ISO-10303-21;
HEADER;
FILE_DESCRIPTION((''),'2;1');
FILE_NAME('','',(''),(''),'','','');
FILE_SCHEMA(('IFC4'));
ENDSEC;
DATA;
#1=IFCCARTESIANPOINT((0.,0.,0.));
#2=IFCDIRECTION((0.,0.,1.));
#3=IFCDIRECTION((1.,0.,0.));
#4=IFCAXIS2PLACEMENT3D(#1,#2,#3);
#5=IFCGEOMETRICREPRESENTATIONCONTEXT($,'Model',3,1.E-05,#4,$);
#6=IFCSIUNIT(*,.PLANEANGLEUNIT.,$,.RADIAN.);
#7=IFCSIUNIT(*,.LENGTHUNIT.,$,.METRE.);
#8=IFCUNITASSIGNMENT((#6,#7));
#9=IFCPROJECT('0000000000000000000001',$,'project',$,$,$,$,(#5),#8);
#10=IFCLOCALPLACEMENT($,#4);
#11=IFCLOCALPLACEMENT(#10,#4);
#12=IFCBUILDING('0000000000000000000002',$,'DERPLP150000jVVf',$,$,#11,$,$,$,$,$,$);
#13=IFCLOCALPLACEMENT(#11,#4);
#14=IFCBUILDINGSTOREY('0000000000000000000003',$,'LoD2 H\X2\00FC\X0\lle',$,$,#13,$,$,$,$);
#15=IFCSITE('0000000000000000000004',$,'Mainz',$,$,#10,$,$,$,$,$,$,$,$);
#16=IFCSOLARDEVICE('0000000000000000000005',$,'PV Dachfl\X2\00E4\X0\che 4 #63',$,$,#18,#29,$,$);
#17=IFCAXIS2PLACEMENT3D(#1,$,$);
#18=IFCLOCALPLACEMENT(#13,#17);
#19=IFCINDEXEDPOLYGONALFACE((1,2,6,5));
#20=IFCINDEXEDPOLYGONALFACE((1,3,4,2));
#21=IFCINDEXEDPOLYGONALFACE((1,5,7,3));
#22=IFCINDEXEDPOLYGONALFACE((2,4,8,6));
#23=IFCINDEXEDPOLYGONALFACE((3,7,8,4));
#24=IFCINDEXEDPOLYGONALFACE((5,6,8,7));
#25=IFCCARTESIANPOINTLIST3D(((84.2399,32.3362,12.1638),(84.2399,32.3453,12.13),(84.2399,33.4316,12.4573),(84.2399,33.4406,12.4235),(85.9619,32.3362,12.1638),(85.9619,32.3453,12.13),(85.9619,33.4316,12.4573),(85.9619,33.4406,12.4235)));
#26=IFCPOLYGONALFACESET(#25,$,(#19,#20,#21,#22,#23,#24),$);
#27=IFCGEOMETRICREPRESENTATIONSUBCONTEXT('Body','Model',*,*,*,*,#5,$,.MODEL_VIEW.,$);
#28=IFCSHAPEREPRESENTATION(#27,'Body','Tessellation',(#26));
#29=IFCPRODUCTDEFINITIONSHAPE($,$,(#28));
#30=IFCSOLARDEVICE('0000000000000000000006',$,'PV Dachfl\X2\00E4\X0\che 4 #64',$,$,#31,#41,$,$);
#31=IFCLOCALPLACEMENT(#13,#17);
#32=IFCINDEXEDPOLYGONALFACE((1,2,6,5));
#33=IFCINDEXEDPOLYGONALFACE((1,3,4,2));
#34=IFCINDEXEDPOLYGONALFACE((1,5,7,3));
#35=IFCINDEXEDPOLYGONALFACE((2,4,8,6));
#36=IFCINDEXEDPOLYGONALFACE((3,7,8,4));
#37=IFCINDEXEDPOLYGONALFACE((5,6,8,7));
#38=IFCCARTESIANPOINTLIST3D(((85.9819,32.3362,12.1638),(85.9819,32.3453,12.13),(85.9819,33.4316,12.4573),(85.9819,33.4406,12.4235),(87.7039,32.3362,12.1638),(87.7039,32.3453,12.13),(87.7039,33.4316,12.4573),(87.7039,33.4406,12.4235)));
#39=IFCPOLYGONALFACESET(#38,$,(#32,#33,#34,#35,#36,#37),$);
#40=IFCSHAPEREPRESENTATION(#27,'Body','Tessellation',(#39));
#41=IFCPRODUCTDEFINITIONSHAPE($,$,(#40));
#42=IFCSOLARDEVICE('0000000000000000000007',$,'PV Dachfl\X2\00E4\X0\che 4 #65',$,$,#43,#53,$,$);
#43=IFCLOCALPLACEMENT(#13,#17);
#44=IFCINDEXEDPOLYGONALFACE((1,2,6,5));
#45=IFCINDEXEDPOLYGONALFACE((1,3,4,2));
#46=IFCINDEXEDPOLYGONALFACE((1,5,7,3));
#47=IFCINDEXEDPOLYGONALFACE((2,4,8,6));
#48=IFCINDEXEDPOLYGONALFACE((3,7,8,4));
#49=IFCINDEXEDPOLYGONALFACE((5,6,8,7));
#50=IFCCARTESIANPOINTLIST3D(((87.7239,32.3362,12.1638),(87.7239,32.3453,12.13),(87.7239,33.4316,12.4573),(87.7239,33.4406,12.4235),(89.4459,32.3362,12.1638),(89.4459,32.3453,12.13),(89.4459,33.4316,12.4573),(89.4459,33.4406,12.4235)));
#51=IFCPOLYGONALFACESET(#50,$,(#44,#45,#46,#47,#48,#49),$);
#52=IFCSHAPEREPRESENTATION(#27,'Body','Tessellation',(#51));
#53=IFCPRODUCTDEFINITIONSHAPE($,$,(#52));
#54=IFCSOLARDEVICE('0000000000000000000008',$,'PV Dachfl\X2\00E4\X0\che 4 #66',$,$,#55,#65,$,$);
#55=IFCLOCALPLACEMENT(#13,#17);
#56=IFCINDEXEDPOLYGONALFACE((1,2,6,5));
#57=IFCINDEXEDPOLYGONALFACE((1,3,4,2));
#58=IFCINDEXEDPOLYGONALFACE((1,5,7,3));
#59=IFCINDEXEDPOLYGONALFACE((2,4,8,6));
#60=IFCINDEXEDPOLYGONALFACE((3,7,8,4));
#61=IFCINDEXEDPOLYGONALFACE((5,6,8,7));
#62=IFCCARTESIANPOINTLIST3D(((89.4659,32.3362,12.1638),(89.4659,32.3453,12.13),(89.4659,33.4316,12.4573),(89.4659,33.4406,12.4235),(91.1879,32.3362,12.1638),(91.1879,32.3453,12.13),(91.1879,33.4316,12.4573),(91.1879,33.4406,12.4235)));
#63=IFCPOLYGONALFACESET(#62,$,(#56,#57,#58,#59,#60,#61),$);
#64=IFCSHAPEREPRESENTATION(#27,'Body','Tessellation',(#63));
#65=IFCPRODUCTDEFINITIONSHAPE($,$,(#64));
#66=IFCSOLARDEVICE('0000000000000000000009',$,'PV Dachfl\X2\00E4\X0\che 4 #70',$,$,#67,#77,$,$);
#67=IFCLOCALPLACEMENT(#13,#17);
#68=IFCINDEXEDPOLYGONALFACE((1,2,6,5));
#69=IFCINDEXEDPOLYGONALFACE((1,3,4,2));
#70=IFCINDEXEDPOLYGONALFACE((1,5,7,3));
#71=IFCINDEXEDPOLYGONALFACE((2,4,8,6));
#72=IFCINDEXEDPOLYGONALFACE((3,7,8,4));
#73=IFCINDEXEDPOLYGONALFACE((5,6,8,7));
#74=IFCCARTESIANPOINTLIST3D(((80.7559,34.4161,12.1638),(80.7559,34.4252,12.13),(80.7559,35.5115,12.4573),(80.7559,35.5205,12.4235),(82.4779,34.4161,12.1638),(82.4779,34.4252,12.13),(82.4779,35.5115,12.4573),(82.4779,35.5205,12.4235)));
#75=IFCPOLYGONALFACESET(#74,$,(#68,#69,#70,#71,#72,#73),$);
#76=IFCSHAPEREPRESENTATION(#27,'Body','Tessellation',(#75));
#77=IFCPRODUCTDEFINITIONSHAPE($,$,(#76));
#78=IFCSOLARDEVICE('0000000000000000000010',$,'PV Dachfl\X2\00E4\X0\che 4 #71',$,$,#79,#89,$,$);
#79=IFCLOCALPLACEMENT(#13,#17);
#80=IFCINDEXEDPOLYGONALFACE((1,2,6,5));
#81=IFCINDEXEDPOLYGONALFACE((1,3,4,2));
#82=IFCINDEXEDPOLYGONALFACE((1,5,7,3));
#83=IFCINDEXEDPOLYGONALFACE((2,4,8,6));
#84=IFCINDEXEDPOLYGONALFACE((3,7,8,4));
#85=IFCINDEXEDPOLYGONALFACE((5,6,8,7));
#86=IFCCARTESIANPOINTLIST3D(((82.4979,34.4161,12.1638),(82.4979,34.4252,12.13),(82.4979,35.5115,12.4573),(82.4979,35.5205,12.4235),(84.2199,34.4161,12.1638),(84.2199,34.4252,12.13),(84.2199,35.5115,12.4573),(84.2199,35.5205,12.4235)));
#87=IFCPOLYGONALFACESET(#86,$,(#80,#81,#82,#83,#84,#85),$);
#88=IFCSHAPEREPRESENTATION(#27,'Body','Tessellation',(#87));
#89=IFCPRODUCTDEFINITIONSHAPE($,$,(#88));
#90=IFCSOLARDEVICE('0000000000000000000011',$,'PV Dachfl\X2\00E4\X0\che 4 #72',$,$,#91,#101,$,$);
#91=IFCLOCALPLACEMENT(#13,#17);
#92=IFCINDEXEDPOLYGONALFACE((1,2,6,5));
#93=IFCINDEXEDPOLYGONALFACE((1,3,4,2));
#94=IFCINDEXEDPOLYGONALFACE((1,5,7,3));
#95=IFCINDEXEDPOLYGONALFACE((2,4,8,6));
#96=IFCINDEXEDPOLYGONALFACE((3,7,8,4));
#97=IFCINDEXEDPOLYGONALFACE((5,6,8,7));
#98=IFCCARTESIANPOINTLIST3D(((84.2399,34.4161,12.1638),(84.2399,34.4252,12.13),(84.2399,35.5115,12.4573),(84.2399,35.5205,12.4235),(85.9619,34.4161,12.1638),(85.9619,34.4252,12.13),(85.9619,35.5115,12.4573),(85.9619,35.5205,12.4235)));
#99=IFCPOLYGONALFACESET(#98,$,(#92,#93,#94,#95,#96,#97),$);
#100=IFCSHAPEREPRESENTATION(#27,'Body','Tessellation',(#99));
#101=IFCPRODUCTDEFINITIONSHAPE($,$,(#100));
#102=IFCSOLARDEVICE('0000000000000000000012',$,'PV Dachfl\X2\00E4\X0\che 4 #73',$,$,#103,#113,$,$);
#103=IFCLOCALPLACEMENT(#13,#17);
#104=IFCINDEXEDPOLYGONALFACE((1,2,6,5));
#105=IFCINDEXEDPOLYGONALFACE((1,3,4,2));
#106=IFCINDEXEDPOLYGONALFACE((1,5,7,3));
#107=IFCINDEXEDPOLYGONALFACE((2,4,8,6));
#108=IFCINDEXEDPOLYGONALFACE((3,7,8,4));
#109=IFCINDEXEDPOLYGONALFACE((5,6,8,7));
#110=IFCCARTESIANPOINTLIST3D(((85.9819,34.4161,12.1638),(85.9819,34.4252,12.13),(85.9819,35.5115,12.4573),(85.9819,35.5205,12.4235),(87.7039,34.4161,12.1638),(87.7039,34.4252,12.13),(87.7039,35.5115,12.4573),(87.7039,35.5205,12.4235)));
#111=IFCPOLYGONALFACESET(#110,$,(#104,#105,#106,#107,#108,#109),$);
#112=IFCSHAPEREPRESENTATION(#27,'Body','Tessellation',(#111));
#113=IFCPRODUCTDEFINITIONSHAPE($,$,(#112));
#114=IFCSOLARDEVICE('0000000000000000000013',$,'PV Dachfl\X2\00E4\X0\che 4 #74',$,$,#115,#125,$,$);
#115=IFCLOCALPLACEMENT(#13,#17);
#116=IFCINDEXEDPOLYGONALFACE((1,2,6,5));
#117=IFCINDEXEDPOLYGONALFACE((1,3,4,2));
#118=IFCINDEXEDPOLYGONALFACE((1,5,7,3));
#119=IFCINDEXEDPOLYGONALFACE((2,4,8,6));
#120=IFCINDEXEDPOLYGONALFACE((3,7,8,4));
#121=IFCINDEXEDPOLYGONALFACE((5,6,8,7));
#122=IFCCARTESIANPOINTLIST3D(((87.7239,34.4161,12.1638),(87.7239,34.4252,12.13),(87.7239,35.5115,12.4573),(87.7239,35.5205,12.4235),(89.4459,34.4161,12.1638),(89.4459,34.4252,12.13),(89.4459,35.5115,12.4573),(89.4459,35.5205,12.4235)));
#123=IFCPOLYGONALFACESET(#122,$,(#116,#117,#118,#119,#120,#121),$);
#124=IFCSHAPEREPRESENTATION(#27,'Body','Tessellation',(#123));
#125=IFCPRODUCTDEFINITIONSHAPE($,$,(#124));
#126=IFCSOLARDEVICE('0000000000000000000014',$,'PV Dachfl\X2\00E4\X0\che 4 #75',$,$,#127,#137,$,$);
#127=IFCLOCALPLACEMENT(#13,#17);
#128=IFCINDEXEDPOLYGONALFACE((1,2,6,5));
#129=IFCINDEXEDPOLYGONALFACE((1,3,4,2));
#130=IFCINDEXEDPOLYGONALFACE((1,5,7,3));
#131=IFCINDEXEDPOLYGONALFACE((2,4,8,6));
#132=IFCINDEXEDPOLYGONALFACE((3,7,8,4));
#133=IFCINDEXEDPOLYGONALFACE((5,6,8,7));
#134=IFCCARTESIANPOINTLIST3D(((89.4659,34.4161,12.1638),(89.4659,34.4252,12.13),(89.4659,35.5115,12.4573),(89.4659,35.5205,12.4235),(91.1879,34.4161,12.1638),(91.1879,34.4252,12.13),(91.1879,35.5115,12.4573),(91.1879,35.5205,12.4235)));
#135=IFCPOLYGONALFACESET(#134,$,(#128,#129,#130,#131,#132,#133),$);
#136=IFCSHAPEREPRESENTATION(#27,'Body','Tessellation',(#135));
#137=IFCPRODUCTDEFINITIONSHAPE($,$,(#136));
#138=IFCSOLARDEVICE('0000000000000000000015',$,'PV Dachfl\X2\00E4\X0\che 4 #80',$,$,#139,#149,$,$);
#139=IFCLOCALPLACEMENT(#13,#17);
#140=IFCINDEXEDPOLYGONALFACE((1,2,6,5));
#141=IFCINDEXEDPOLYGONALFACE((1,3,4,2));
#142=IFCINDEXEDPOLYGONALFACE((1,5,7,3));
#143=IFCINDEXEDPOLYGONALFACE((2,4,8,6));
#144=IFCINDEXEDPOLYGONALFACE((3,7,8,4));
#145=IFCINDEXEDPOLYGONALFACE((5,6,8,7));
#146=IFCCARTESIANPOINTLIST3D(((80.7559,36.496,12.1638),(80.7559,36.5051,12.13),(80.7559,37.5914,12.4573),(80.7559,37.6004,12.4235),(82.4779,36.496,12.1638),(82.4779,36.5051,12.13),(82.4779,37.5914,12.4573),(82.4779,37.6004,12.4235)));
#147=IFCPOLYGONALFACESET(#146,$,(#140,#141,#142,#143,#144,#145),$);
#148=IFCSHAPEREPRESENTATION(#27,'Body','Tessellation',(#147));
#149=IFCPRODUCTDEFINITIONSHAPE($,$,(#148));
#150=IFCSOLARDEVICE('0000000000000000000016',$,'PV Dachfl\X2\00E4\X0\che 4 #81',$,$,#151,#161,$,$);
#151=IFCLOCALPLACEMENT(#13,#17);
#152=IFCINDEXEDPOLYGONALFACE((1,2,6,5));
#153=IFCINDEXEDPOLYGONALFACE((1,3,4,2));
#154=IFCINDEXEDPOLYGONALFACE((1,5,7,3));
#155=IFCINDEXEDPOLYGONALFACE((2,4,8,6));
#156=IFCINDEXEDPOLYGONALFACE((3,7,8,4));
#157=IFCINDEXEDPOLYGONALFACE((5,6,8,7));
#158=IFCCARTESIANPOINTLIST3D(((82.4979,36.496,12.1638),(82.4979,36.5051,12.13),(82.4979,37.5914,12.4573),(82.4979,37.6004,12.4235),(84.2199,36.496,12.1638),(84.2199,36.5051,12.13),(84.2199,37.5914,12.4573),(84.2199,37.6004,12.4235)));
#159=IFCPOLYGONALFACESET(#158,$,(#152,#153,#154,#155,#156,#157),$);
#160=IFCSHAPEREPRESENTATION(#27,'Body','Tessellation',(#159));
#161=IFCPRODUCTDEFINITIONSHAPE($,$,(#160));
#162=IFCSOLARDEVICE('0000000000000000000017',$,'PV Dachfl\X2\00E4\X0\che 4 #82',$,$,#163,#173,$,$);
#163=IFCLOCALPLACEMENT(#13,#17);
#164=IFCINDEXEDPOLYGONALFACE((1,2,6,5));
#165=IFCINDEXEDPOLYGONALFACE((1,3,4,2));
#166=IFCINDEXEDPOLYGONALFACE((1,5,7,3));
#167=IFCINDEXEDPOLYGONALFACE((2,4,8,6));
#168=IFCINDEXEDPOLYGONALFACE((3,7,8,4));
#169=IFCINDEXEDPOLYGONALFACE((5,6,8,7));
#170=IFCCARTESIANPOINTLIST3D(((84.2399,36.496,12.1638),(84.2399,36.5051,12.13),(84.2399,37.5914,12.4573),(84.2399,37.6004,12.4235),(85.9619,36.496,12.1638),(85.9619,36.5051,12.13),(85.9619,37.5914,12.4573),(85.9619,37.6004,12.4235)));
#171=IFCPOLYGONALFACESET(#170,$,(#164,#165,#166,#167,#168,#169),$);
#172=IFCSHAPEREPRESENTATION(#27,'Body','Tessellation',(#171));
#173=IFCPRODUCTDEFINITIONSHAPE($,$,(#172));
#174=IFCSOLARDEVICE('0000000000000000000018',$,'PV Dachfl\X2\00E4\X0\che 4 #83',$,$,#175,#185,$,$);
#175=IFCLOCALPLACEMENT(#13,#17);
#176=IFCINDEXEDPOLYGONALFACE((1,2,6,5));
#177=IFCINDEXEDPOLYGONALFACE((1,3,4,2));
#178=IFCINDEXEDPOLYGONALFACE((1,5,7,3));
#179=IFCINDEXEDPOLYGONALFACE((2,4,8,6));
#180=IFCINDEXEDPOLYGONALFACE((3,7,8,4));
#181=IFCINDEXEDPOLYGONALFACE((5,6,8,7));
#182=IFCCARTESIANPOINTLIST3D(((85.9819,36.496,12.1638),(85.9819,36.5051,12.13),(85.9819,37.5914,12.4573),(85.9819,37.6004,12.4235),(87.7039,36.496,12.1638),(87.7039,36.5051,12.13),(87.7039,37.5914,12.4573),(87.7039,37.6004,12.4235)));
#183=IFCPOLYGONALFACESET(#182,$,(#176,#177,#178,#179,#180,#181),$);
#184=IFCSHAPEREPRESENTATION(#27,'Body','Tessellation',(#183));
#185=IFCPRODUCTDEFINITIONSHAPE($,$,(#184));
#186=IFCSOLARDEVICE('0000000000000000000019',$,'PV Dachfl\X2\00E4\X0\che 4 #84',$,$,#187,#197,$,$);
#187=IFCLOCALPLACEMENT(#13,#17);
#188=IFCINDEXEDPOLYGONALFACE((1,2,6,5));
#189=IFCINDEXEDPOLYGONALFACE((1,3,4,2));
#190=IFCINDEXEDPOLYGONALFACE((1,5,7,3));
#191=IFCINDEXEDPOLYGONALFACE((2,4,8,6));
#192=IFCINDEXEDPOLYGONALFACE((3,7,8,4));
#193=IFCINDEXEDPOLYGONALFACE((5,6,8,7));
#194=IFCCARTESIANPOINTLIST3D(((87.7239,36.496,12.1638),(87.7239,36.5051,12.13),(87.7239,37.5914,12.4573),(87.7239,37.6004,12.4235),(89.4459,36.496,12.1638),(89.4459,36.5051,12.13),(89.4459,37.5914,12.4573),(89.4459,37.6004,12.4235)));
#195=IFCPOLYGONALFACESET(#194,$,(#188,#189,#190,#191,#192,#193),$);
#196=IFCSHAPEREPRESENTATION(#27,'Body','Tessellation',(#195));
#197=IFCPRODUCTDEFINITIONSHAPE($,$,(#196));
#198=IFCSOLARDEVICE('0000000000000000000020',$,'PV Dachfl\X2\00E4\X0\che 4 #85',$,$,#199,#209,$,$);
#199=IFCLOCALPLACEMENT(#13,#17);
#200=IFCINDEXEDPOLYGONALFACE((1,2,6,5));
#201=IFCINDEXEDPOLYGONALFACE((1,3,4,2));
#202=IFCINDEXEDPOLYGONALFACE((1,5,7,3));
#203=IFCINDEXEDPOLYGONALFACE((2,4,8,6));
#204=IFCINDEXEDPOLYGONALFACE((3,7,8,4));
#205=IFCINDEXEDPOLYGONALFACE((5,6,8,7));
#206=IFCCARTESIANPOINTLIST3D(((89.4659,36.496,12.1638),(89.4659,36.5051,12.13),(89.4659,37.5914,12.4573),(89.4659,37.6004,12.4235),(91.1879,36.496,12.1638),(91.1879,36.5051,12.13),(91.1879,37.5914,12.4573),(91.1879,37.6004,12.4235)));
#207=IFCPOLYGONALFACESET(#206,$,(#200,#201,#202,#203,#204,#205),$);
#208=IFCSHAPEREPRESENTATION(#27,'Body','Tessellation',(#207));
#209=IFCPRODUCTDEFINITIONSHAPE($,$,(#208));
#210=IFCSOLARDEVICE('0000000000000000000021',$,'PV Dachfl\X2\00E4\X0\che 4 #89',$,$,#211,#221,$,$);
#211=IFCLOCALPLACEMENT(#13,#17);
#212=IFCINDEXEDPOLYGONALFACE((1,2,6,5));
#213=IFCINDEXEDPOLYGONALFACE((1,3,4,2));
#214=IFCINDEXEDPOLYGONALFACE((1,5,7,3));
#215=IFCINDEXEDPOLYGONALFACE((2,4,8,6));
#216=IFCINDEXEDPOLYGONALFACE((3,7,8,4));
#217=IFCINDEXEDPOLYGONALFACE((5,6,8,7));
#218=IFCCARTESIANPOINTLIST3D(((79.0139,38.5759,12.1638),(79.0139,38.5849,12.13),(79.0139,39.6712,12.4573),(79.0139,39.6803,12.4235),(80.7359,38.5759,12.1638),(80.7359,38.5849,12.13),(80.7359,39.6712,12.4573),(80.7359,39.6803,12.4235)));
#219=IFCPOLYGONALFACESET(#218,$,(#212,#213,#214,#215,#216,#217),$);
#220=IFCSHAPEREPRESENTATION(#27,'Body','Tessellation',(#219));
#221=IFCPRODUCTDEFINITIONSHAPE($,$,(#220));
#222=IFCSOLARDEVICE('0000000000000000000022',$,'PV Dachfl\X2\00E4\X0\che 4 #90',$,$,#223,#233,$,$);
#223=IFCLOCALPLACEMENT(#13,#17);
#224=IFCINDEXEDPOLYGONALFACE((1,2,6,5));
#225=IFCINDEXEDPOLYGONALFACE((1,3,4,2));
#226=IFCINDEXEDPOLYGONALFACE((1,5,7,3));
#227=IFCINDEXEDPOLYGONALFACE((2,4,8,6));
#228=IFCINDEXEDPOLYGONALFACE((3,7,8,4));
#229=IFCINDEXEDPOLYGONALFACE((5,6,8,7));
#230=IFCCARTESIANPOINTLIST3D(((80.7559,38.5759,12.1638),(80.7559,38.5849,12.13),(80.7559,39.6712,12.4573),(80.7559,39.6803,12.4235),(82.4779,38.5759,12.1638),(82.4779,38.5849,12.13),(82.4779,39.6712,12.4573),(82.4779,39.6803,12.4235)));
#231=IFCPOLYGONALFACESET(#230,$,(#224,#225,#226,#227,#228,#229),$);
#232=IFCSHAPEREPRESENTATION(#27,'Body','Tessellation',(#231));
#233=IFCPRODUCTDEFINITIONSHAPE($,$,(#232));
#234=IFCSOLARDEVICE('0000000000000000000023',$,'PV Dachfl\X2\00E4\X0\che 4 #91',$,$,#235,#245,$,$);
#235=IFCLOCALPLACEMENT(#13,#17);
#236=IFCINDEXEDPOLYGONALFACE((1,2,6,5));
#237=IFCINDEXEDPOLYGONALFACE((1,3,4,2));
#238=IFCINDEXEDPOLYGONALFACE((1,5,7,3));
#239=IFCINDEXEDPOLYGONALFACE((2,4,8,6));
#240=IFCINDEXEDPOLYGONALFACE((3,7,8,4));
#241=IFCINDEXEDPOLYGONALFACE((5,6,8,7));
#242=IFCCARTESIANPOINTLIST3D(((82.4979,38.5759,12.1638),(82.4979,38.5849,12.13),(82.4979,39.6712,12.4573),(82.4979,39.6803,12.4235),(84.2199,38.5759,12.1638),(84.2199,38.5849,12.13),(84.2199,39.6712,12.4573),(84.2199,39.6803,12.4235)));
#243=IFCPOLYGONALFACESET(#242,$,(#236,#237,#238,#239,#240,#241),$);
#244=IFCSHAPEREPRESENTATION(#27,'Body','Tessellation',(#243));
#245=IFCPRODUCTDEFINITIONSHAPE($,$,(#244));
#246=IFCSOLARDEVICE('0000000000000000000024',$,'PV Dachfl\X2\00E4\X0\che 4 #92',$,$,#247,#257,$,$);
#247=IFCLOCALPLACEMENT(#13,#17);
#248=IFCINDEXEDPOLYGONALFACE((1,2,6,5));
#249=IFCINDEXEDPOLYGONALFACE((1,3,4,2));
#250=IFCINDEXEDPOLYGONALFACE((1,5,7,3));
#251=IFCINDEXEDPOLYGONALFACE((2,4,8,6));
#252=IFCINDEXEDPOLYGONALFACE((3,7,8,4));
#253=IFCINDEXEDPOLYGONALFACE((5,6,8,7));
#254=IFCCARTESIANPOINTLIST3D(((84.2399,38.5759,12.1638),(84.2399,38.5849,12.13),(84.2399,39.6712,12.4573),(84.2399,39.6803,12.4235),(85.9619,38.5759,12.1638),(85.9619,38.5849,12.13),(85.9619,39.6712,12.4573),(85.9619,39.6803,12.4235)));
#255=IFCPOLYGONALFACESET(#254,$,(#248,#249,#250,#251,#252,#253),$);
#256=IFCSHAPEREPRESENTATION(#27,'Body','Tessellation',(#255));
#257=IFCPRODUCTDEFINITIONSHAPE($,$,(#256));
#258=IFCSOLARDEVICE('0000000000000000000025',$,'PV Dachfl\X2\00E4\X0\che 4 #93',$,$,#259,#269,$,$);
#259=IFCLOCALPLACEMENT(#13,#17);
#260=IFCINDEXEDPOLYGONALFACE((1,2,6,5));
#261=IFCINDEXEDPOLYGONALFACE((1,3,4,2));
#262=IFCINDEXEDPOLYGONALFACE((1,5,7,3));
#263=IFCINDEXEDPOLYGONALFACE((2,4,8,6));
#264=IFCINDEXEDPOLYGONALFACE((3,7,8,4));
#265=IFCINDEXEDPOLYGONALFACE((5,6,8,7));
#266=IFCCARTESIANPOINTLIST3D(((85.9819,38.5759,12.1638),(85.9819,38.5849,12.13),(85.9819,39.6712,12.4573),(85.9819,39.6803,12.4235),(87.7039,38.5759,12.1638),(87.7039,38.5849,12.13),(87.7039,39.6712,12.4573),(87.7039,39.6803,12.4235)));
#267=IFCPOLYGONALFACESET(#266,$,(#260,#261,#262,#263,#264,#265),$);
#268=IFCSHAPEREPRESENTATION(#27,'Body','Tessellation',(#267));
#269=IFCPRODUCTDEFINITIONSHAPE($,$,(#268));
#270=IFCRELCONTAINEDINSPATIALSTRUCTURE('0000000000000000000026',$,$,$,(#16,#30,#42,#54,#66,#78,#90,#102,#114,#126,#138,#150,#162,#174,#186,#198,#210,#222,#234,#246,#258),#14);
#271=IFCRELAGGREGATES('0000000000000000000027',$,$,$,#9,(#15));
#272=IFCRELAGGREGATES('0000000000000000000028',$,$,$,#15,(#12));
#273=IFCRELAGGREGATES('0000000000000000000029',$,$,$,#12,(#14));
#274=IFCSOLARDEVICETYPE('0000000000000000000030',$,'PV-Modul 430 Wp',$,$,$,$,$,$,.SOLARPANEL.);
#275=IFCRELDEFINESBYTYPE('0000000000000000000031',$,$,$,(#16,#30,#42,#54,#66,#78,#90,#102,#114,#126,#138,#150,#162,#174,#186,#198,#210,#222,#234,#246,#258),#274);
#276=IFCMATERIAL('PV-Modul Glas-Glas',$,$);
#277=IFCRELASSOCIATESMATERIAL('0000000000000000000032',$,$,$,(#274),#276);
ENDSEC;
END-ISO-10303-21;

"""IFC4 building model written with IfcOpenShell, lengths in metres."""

from ifc_helpers import new_model, si_unit, frame, frame_2d, origin, origin_with_axes, place, context, subcontext, project, spatial, rectangle, extrude, source, transform, mapped, material, type_object, type_shapes, element, save


model = new_model("IFC4")

# Units and contexts
model_context = context("Model", 3, precision=1e-05, world=origin_with_axes())
body_context = subcontext(model_context, "Body", "Model", "MODEL_VIEW")
ifc_project = project(units=[si_unit("PLANEANGLEUNIT", "RADIAN"), si_unit("LENGTHUNIT", "METRE")], contexts=[model_context])

# Site, building, storey
site_placement = place(None, origin_with_axes())
site = spatial("IfcSite", under=ifc_project, at=site_placement, Name="Mainz")
building_placement = place(site_placement, origin_with_axes())
building = spatial("IfcBuilding", under=site, at=building_placement, Name="DERPLP150000jVVf")
storey_placement = place(building_placement, origin_with_axes())
storey = spatial("IfcBuildingStorey", under=building, at=storey_placement, Name="LoD2 Hülle")

# Solar devices
ifc_material = material(Name="PV-Modul Glas-Glas")
solar_device_type = type_object("IfcSolarDeviceType", Name="PV-Modul 430 Wp", PredefinedType="SOLARPANEL", material=ifc_material)
shared_shape = source(origin_with_axes(), body_context, "Body", "SweptSolid", [
    extrude(rectangle(XDim=1.722, YDim=1.134, at=frame_2d((0.861, 0.567))), origin(), (0.0, 0.0, 1.0), 0.035),
])
type_shapes(solar_device_type, [shared_shape])
for number, where, z_axis, x_axis, name in (
    (1, (84.2399, 32.3453, 12.13), (0.0, -0.258819, 0.965926), (1.0, 0.0, 0.0), "PV Dachfläche 4 #63"),
    (2, (85.9819, 32.3453, 12.13), (0.0, -0.258819, 0.965926), (1.0, 0.0, 0.0), "PV Dachfläche 4 #64"),
    (3, (87.7239, 32.3453, 12.13), (0.0, -0.258819, 0.965926), (1.0, 0.0, 0.0), "PV Dachfläche 4 #65"),
    (4, (89.4659, 32.3453, 12.13), (0.0, -0.258819, 0.965926), (1.0, 0.0, 0.0), "PV Dachfläche 4 #66"),
    (5, (80.7559, 34.4252, 12.13), (0.0, -0.258819, 0.965926), (1.0, 0.0, 0.0), "PV Dachfläche 4 #70"),
    (6, (82.4979, 34.4252, 12.13), (0.0, -0.258819, 0.965926), (1.0, 0.0, 0.0), "PV Dachfläche 4 #71"),
    (7, (84.2399, 34.4252, 12.13), (0.0, -0.258819, 0.965926), (1.0, 0.0, 0.0), "PV Dachfläche 4 #72"),
    (8, (85.9819, 34.4252, 12.13), (0.0, -0.258819, 0.965926), (1.0, 0.0, 0.0), "PV Dachfläche 4 #73"),
    (9, (87.7239, 34.4252, 12.13), (0.0, -0.258819, 0.965926), (1.0, 0.0, 0.0), "PV Dachfläche 4 #74"),
    (10, (89.4659, 34.4252, 12.13), (0.0, -0.258819, 0.965926), (1.0, 0.0, 0.0), "PV Dachfläche 4 #75"),
    (11, (80.7559, 36.5051, 12.13), (0.0, -0.258819, 0.965926), (1.0, 0.0, 0.0), "PV Dachfläche 4 #80"),
    (12, (82.4979, 36.5051, 12.13), (0.0, -0.258819, 0.965926), (1.0, 0.0, 0.0), "PV Dachfläche 4 #81"),
    (13, (84.2399, 36.5051, 12.13), (0.0, -0.258819, 0.965926), (1.0, 0.0, 0.0), "PV Dachfläche 4 #82"),
    (14, (85.9819, 36.5051, 12.13), (0.0, -0.258819, 0.965926), (1.0, 0.0, 0.0), "PV Dachfläche 4 #83"),
    (15, (87.7239, 36.5051, 12.13), (0.0, -0.258819, 0.965926), (1.0, 0.0, 0.0), "PV Dachfläche 4 #84"),
    (16, (89.4659, 36.5051, 12.13), (0.0, -0.258819, 0.965926), (1.0, 0.0, 0.0), "PV Dachfläche 4 #85"),
    (17, (79.0139, 38.5849, 12.13), (0.0, -0.258819, 0.965926), (1.0, 0.0, 0.0), "PV Dachfläche 4 #89"),
    (18, (80.7559, 38.5849, 12.13), (0.0, -0.258819, 0.965926), (1.0, 0.0, 0.0), "PV Dachfläche 4 #90"),
    (19, (82.4979, 38.5849, 12.13), (0.0, -0.258819, 0.965926), (1.0, 0.0, 0.0), "PV Dachfläche 4 #91"),
    (20, (84.2399, 38.5849, 12.13), (0.0, -0.258819, 0.965926), (1.0, 0.0, 0.0), "PV Dachfläche 4 #92"),
    (21, (85.9819, 38.5849, 12.13), (0.0, -0.258819, 0.965926), (1.0, 0.0, 0.0), "PV Dachfläche 4 #93"),
):
    element("IfcSolarDevice", number, at=place(storey_placement, frame(where, z_axis=z_axis, x_axis=x_axis)), inside=storey, type_object=solar_device_type, Name=name, context=body_context, shape_type="MappedRepresentation", body=[
        mapped(shared_shape, transform((0.0, 0.0, 0.0), x_axis=(1.0, 0.0, 0.0), y_axis=(0.0, 1.0, 0.0), z_axis=(0.0, 0.0, 1.0), scale=1.0)),
    ])

save(model, "model.ifc")
